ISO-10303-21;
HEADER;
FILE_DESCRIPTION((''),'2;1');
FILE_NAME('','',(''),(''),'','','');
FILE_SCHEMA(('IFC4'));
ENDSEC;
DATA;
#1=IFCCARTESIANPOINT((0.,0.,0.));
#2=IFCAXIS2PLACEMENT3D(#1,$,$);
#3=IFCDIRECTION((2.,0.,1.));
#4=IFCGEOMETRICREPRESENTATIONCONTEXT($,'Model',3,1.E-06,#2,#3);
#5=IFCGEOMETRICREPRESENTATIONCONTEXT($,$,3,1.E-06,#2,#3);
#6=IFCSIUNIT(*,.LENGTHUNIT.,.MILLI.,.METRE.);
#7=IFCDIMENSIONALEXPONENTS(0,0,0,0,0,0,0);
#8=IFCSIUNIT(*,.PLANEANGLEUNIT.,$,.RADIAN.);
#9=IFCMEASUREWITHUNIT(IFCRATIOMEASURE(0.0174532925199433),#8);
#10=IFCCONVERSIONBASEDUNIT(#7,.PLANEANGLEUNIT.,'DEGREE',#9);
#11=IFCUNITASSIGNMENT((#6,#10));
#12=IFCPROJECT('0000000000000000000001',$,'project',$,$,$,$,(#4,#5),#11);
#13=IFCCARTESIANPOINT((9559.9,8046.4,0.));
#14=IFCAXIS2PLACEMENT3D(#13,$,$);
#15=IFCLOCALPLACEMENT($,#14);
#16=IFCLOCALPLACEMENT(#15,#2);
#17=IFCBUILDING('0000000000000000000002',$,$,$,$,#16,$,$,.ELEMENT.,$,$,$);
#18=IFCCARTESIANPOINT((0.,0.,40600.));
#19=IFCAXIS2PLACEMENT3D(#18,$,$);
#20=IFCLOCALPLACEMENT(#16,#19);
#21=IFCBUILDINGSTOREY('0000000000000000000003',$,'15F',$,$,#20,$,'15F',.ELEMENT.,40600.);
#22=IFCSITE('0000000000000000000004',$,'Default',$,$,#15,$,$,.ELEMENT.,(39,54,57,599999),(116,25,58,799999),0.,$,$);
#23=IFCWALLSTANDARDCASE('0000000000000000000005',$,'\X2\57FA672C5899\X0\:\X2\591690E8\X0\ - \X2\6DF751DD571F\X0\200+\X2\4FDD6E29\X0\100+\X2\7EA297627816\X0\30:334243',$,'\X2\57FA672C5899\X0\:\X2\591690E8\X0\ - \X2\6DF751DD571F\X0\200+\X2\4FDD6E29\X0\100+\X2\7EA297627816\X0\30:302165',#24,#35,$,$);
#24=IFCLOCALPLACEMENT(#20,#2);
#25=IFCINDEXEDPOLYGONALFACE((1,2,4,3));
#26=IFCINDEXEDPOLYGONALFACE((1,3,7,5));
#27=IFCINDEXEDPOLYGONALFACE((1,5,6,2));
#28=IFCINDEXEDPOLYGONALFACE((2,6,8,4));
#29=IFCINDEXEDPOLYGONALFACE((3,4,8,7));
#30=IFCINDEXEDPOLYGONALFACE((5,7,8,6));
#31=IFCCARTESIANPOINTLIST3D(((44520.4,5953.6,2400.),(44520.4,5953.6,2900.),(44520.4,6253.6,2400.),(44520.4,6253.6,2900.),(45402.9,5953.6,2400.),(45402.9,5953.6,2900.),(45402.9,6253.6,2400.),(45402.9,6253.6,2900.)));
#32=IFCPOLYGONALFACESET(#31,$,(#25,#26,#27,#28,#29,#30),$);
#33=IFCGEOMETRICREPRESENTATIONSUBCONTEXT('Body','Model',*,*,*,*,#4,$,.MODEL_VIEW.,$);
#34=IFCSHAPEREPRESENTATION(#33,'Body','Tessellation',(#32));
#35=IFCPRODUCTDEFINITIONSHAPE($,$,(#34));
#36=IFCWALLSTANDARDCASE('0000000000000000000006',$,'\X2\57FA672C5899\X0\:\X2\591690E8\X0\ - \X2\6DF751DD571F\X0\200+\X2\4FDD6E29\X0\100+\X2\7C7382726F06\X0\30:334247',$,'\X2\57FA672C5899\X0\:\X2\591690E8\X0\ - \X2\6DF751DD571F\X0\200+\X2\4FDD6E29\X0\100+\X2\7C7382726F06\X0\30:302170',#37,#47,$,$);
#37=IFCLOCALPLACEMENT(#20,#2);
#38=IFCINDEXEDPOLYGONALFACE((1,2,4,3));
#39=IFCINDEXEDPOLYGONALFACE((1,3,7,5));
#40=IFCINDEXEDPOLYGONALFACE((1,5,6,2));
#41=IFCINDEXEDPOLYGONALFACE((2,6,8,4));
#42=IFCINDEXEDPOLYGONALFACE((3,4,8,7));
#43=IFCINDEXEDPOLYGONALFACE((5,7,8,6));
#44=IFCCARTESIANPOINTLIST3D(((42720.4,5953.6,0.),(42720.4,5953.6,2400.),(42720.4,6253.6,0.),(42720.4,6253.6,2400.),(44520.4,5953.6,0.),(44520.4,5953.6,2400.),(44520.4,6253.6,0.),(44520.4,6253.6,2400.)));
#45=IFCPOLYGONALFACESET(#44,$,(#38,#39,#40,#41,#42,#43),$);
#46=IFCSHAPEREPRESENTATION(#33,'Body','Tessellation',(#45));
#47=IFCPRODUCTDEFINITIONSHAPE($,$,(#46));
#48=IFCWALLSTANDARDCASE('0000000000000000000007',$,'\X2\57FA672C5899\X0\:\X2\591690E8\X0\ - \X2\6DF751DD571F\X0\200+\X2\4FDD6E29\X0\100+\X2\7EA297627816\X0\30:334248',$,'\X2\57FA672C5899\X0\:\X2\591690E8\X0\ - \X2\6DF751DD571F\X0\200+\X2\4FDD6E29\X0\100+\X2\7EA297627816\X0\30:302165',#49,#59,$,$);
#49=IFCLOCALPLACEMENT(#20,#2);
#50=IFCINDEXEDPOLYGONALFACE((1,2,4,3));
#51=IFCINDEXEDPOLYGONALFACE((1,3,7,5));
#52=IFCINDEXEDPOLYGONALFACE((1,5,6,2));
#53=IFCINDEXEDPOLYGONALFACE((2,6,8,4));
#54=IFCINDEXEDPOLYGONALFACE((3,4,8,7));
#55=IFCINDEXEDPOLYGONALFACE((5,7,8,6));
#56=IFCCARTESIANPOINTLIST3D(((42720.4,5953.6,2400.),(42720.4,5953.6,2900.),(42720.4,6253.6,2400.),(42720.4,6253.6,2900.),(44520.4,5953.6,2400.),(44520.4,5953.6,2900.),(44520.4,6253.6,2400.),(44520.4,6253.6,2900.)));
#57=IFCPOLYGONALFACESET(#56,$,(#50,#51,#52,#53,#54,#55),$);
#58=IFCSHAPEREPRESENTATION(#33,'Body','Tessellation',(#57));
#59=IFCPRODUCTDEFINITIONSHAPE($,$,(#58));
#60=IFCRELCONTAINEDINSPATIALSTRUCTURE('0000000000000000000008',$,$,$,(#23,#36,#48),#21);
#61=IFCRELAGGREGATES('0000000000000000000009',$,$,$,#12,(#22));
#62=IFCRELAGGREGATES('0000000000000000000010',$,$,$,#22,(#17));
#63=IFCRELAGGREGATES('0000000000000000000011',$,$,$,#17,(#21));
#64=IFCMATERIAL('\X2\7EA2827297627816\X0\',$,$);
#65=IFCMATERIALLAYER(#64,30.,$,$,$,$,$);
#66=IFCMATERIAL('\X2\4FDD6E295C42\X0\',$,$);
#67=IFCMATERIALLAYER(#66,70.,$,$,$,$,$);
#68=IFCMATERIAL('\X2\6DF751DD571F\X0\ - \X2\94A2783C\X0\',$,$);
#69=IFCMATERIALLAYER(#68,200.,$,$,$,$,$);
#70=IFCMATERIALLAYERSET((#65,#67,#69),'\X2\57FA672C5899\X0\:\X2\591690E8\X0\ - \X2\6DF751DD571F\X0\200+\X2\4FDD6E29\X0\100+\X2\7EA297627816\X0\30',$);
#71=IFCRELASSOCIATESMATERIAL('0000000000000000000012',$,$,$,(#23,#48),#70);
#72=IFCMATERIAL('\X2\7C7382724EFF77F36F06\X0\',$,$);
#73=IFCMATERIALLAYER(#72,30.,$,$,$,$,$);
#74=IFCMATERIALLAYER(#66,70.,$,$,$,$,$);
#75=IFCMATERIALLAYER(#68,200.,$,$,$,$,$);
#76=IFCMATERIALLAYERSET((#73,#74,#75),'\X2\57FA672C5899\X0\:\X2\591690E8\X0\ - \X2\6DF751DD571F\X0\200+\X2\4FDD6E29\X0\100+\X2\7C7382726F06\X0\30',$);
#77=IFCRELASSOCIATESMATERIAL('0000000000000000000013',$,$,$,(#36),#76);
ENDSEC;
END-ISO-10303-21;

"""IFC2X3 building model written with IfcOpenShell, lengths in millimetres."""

from ifc_helpers import new_model, entity, si_unit, converted_unit, direction, frame, frame_2d, origin, place, context, subcontext, project, spatial, rectangle, extrude, material, layer, layer_set, layer_usage, element, save


model = new_model("IFC2X3")

# Units and contexts
model_context = context("Model", 3, precision=1e-06, world=origin(), true_north=direction((2.0, 0.0, 1.0)))
context_of_model = context(None, 3, precision=1e-06, world=origin(), true_north=direction((2.0, 0.0, 1.0)))
body_context = subcontext(model_context, "Body", "Model", "MODEL_VIEW")
ifc_project = project(units=[si_unit("LENGTHUNIT", "METRE", prefix="MILLI"), converted_unit("PLANEANGLEUNIT", "DEGREE", entity("IfcRatioMeasure", 0.0174532925199433), si_unit("PLANEANGLEUNIT", "RADIAN"), dimensions=[0, 0, 0, 0, 0, 0, 0])], contexts=[model_context, context_of_model])

# Site, building, storey
site_placement = place(None, frame((9559.9, 8046.4, 0.0)))
site = spatial("IfcSite", under=ifc_project, at=site_placement, Name="Default", CompositionType="ELEMENT", RefLatitude=(39, 54, 57, 599999), RefLongitude=(116, 25, 58, 799999), RefElevation=0.0)
building_placement = place(site_placement, origin())
building = spatial("IfcBuilding", under=site, at=building_placement, CompositionType="ELEMENT")
storey_placement = place(building_placement, frame((0.0, 0.0, 40600.0)))
storey = spatial("IfcBuildingStorey", under=building, at=storey_placement, Name="15F", LongName="15F", CompositionType="ELEMENT", Elevation=40600.0)

# Shared definitions
ifc_material_1 = material(Name="红色面砖")
ifc_layer_1 = layer(ifc_material_1, 30.0)
ifc_material_2 = material(Name="保温层")
ifc_layer_2 = layer(ifc_material_2, 70.0)
ifc_material_3 = material(Name="混凝土 - 钢砼")
ifc_layer_3 = layer(ifc_material_3, 200.0)
ifc_layer_set_1 = layer_set([ifc_layer_1, ifc_layer_2, ifc_layer_3], Name="基本墙:外部 - 混凝土200+保温100+红面砖30")

# Shared definitions
ifc_material_4 = material(Name="米色仿石漆")
ifc_layer_4 = layer(ifc_material_4, 30.0)
ifc_layer_5 = layer(ifc_material_2, 70.0)
ifc_layer_6 = layer(ifc_material_3, 200.0)
ifc_layer_set_2 = layer_set([ifc_layer_4, ifc_layer_5, ifc_layer_6], Name="基本墙:外部 - 混凝土200+保温100+米色漆30")

# Walls
ifc_layer_usage_1 = layer_usage(ifc_layer_set_1, "AXIS2", "NEGATIVE", 150.0)
wall_1_placement = place(storey_placement, frame((44520.4, 6103.6, 2400.0)))
element("IfcWallStandardCase", 1, at=wall_1_placement, inside=storey, material=ifc_layer_usage_1, Name="基本墙:外部 - 混凝土200+保温100+红面砖30:334243", ObjectType="基本墙:外部 - 混凝土200+保温100+红面砖30:302165", context=body_context, shape_type="SweptSolid", body=[
    extrude(rectangle(XDim=882.5, YDim=300.0, at=frame_2d((441.2, 0.0), x_axis=(-1.0, 0.0))), origin(), (0.0, 0.0, 1.0), 500.0),
])
ifc_layer_usage_2 = layer_usage(ifc_layer_set_2, "AXIS2", "NEGATIVE", 150.0)
wall_2_placement = place(storey_placement, frame((42720.4, 6103.6, 0.0)))
element("IfcWallStandardCase", 2, at=wall_2_placement, inside=storey, material=ifc_layer_usage_2, Name="基本墙:外部 - 混凝土200+保温100+米色漆30:334247", ObjectType="基本墙:外部 - 混凝土200+保温100+米色漆30:302170", context=body_context, shape_type="SweptSolid", body=[
    extrude(rectangle(XDim=1800.0, YDim=300.0, at=frame_2d((900.0, 0.0), x_axis=(-1.0, 0.0))), origin(), (0.0, 0.0, 1.0), 2400.0),
])
ifc_layer_usage_3 = layer_usage(ifc_layer_set_1, "AXIS2", "NEGATIVE", 150.0)
wall_3_placement = place(storey_placement, frame((42720.4, 6103.6, 2400.0)))
element("IfcWallStandardCase", 3, at=wall_3_placement, inside=storey, material=ifc_layer_usage_3, Name="基本墙:外部 - 混凝土200+保温100+红面砖30:334248", ObjectType="基本墙:外部 - 混凝土200+保温100+红面砖30:302165", context=body_context, shape_type="SweptSolid", body=[
    extrude(rectangle(XDim=1800.0, YDim=300.0, at=frame_2d((900.0, 0.0), x_axis=(-1.0, 0.0))), origin(), (0.0, 0.0, 1.0), 500.0),
])

save(model, "model.ifc")
